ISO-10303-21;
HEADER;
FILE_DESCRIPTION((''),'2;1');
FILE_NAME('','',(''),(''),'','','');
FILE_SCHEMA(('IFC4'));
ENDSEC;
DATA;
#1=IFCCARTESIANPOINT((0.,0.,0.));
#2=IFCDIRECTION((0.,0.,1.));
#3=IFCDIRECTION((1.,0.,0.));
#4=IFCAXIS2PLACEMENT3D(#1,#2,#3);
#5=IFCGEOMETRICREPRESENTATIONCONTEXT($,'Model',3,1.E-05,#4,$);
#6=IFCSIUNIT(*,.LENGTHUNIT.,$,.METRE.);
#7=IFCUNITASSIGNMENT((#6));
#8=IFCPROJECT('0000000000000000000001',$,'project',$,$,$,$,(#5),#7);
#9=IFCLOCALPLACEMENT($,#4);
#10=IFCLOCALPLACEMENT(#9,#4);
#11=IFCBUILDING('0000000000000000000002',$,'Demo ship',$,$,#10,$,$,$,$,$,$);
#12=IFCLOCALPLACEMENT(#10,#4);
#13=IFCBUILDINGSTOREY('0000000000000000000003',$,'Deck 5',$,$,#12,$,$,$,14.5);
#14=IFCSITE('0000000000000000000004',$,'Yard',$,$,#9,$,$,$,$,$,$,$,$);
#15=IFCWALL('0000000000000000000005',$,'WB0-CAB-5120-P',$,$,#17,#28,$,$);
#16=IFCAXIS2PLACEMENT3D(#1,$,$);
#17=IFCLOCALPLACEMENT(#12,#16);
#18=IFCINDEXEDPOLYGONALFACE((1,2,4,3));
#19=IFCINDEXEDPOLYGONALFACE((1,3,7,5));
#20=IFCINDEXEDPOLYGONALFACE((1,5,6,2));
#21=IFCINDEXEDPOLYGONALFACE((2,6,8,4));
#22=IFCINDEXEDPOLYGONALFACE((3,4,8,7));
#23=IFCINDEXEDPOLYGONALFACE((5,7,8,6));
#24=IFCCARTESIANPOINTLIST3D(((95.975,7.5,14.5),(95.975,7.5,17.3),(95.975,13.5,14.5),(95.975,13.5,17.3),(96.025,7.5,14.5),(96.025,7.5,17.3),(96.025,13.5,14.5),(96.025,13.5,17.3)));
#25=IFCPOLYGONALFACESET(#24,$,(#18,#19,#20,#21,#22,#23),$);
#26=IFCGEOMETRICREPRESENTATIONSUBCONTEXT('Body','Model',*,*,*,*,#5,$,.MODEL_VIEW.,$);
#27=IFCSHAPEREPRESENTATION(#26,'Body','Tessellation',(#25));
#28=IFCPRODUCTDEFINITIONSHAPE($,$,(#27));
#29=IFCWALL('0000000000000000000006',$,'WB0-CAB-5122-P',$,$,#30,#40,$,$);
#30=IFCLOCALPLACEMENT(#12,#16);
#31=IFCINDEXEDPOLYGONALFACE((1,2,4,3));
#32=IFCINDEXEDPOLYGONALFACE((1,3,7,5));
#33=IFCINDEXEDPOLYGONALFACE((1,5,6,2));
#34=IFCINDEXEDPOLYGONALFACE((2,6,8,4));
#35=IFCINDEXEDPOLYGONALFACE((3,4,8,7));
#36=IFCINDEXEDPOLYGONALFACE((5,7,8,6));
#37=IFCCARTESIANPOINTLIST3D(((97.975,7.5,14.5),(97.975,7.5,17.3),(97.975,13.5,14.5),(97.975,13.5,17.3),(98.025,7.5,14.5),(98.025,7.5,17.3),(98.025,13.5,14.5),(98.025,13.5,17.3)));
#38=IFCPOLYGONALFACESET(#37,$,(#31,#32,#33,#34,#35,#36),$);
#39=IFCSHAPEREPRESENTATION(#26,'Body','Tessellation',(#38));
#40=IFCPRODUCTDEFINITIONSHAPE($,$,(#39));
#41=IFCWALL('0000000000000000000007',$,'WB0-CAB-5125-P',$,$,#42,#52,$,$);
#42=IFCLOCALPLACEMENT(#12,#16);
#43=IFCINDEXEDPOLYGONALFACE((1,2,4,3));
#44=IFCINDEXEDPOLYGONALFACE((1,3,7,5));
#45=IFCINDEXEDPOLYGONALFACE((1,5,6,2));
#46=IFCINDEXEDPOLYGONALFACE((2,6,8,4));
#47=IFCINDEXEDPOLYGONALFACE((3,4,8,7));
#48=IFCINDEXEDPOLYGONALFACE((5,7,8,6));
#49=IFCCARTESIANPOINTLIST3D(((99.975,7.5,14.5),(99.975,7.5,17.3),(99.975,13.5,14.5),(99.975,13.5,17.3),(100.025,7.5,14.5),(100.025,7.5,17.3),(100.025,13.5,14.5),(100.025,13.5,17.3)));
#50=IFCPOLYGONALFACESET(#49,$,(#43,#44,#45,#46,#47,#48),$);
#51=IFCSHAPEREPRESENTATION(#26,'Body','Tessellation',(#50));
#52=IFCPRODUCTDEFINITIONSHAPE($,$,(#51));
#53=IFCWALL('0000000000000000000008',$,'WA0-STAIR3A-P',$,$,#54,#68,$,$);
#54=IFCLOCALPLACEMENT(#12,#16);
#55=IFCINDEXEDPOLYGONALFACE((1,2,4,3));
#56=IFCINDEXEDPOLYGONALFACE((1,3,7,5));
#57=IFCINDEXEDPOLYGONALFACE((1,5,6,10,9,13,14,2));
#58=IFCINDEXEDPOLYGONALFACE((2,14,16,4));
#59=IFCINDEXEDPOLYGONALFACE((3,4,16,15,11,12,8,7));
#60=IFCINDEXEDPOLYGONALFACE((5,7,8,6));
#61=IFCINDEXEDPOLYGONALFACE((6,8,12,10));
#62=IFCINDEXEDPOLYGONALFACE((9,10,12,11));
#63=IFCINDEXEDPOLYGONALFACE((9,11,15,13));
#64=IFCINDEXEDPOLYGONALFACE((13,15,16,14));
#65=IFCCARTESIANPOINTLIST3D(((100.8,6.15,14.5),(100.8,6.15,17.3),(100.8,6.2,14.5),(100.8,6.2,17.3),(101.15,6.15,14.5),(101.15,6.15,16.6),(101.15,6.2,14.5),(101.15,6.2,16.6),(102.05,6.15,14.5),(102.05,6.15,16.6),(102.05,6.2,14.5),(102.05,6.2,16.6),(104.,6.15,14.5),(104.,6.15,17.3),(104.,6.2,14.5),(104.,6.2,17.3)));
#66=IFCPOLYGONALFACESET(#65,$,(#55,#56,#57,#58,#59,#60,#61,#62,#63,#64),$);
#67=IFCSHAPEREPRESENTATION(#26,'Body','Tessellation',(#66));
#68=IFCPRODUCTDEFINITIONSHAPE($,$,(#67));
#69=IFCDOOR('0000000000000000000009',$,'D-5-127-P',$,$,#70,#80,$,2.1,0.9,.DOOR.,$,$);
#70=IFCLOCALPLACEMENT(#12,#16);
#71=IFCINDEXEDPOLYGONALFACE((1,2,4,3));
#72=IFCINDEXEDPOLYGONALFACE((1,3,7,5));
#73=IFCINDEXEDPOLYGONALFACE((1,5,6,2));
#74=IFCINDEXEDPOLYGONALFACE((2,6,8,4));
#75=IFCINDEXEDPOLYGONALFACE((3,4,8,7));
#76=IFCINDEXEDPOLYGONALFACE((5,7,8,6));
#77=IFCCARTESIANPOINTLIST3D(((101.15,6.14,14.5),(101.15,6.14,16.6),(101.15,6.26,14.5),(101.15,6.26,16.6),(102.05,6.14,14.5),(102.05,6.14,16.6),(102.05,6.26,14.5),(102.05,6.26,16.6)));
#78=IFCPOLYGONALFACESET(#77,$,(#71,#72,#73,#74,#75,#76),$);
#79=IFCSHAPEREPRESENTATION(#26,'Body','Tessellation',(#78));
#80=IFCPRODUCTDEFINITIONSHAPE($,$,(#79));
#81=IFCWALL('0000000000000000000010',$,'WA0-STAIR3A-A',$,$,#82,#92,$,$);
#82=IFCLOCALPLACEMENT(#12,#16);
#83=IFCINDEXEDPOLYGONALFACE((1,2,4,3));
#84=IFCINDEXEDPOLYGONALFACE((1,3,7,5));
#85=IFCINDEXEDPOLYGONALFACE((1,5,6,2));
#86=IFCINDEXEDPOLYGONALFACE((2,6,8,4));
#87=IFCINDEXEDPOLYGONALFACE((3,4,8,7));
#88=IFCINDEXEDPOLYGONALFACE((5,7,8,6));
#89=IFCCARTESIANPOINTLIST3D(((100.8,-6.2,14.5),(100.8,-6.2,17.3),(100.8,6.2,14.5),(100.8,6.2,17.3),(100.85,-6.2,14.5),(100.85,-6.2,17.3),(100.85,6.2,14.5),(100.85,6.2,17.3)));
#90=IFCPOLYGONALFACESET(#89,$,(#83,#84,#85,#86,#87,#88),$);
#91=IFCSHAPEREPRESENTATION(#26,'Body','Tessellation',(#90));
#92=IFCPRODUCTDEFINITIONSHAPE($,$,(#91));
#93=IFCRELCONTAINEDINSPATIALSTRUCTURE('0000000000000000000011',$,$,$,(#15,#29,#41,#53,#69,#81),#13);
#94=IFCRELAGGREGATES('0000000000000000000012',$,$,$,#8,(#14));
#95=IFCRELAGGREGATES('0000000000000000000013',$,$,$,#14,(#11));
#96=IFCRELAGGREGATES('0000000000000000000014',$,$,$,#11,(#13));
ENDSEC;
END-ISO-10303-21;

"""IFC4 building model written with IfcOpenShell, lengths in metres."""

from ifc_helpers import new_model, si_unit, frame, frame_2d, origin, origin_with_axes, place, context, subcontext, project, spatial, rectangle, extrude, element, fill, save


model = new_model("IFC4")

# Units and contexts
model_context = context("Model", 3, precision=1e-05, world=origin_with_axes())
body_context = subcontext(model_context, "Body", "Model", "MODEL_VIEW")
ifc_project = project(units=[si_unit("LENGTHUNIT", "METRE")], contexts=[model_context])

# Site, building, storey
site_placement = place(None, origin_with_axes())
site = spatial("IfcSite", under=ifc_project, at=site_placement, Name="Yard")
building_placement = place(site_placement, origin_with_axes())
building = spatial("IfcBuilding", under=site, at=building_placement, Name="Demo ship")
storey_placement = place(building_placement, origin_with_axes())
storey = spatial("IfcBuildingStorey", under=building, at=storey_placement, Name="Deck 5", Elevation=14.5)

# Walls
for number, where, z_axis, x_axis, name in (
    (1, (95.975, 7.5, 14.5), (0.0, 0.0, 1.0), (1.0, 0.0, 0.0), "WB0-CAB-5120-P"),
    (2, (97.975, 7.5, 14.5), (0.0, 0.0, 1.0), (1.0, 0.0, 0.0), "WB0-CAB-5122-P"),
    (3, (99.975, 7.5, 14.5), (0.0, 0.0, 1.0), (1.0, 0.0, 0.0), "WB0-CAB-5125-P"),
):
    element("IfcWall", number, at=place(storey_placement, frame(where, z_axis=z_axis, x_axis=x_axis)), inside=storey, Name=name, context=body_context, shape_type="SweptSolid", body=[
        extrude(rectangle(XDim=0.05, YDim=6.0, at=frame_2d((0.025, 3.0))), origin(), (0.0, 0.0, 1.0), 2.8),
    ])

# Wall, opening, door
wall_1_placement = place(storey_placement, frame((100.8, 6.15, 14.5), z_axis=(0.0, 0.0, 1.0), x_axis=(1.0, 0.0, 0.0)))
wall_1 = element("IfcWall", 4, at=wall_1_placement, inside=storey, Name="WA0-STAIR3A-P", context=body_context, shape_type="SweptSolid", body=[
    extrude(rectangle(XDim=3.2, YDim=0.05, at=frame_2d((1.6, 0.025))), origin(), (0.0, 0.0, 1.0), 2.8),
])
opening_1_placement = place(None, frame((101.15, 6.14, 14.5), z_axis=(0.0, 0.0, 1.0), x_axis=(1.0, 0.0, 0.0)))
opening_1 = element("IfcOpeningElement", 5, at=opening_1_placement, cuts=wall_1, context=body_context, shape_type="SweptSolid", body=[
    extrude(rectangle(XDim=0.9, YDim=0.12, at=frame_2d((0.45, 0.06))), origin(), (0.0, 0.0, 1.0), 2.1),
])
door_1_placement = place(storey_placement, frame((101.15, 6.14, 14.5), z_axis=(0.0, 0.0, 1.0), x_axis=(1.0, 0.0, 0.0)))
door_1 = element("IfcDoor", 6, at=door_1_placement, inside=storey, Name="D-5-127-P", OverallHeight=2.1, OverallWidth=0.9, PredefinedType="DOOR", context=body_context, shape_type="SweptSolid", body=[
    extrude(rectangle(XDim=0.9, YDim=0.12, at=frame_2d((0.45, 0.06))), origin(), (0.0, 0.0, 1.0), 2.1),
])
fill(opening_1, door_1)

# Wall
wall_2_placement = place(storey_placement, frame((100.8, -6.2, 14.5), z_axis=(0.0, 0.0, 1.0), x_axis=(1.0, 0.0, 0.0)))
element("IfcWall", 7, at=wall_2_placement, inside=storey, Name="WA0-STAIR3A-A", context=body_context, shape_type="SweptSolid", body=[
    extrude(rectangle(XDim=0.05, YDim=12.4, at=frame_2d((0.025, 6.2))), origin(), (0.0, 0.0, 1.0), 2.8),
])

save(model, "model.ifc")
